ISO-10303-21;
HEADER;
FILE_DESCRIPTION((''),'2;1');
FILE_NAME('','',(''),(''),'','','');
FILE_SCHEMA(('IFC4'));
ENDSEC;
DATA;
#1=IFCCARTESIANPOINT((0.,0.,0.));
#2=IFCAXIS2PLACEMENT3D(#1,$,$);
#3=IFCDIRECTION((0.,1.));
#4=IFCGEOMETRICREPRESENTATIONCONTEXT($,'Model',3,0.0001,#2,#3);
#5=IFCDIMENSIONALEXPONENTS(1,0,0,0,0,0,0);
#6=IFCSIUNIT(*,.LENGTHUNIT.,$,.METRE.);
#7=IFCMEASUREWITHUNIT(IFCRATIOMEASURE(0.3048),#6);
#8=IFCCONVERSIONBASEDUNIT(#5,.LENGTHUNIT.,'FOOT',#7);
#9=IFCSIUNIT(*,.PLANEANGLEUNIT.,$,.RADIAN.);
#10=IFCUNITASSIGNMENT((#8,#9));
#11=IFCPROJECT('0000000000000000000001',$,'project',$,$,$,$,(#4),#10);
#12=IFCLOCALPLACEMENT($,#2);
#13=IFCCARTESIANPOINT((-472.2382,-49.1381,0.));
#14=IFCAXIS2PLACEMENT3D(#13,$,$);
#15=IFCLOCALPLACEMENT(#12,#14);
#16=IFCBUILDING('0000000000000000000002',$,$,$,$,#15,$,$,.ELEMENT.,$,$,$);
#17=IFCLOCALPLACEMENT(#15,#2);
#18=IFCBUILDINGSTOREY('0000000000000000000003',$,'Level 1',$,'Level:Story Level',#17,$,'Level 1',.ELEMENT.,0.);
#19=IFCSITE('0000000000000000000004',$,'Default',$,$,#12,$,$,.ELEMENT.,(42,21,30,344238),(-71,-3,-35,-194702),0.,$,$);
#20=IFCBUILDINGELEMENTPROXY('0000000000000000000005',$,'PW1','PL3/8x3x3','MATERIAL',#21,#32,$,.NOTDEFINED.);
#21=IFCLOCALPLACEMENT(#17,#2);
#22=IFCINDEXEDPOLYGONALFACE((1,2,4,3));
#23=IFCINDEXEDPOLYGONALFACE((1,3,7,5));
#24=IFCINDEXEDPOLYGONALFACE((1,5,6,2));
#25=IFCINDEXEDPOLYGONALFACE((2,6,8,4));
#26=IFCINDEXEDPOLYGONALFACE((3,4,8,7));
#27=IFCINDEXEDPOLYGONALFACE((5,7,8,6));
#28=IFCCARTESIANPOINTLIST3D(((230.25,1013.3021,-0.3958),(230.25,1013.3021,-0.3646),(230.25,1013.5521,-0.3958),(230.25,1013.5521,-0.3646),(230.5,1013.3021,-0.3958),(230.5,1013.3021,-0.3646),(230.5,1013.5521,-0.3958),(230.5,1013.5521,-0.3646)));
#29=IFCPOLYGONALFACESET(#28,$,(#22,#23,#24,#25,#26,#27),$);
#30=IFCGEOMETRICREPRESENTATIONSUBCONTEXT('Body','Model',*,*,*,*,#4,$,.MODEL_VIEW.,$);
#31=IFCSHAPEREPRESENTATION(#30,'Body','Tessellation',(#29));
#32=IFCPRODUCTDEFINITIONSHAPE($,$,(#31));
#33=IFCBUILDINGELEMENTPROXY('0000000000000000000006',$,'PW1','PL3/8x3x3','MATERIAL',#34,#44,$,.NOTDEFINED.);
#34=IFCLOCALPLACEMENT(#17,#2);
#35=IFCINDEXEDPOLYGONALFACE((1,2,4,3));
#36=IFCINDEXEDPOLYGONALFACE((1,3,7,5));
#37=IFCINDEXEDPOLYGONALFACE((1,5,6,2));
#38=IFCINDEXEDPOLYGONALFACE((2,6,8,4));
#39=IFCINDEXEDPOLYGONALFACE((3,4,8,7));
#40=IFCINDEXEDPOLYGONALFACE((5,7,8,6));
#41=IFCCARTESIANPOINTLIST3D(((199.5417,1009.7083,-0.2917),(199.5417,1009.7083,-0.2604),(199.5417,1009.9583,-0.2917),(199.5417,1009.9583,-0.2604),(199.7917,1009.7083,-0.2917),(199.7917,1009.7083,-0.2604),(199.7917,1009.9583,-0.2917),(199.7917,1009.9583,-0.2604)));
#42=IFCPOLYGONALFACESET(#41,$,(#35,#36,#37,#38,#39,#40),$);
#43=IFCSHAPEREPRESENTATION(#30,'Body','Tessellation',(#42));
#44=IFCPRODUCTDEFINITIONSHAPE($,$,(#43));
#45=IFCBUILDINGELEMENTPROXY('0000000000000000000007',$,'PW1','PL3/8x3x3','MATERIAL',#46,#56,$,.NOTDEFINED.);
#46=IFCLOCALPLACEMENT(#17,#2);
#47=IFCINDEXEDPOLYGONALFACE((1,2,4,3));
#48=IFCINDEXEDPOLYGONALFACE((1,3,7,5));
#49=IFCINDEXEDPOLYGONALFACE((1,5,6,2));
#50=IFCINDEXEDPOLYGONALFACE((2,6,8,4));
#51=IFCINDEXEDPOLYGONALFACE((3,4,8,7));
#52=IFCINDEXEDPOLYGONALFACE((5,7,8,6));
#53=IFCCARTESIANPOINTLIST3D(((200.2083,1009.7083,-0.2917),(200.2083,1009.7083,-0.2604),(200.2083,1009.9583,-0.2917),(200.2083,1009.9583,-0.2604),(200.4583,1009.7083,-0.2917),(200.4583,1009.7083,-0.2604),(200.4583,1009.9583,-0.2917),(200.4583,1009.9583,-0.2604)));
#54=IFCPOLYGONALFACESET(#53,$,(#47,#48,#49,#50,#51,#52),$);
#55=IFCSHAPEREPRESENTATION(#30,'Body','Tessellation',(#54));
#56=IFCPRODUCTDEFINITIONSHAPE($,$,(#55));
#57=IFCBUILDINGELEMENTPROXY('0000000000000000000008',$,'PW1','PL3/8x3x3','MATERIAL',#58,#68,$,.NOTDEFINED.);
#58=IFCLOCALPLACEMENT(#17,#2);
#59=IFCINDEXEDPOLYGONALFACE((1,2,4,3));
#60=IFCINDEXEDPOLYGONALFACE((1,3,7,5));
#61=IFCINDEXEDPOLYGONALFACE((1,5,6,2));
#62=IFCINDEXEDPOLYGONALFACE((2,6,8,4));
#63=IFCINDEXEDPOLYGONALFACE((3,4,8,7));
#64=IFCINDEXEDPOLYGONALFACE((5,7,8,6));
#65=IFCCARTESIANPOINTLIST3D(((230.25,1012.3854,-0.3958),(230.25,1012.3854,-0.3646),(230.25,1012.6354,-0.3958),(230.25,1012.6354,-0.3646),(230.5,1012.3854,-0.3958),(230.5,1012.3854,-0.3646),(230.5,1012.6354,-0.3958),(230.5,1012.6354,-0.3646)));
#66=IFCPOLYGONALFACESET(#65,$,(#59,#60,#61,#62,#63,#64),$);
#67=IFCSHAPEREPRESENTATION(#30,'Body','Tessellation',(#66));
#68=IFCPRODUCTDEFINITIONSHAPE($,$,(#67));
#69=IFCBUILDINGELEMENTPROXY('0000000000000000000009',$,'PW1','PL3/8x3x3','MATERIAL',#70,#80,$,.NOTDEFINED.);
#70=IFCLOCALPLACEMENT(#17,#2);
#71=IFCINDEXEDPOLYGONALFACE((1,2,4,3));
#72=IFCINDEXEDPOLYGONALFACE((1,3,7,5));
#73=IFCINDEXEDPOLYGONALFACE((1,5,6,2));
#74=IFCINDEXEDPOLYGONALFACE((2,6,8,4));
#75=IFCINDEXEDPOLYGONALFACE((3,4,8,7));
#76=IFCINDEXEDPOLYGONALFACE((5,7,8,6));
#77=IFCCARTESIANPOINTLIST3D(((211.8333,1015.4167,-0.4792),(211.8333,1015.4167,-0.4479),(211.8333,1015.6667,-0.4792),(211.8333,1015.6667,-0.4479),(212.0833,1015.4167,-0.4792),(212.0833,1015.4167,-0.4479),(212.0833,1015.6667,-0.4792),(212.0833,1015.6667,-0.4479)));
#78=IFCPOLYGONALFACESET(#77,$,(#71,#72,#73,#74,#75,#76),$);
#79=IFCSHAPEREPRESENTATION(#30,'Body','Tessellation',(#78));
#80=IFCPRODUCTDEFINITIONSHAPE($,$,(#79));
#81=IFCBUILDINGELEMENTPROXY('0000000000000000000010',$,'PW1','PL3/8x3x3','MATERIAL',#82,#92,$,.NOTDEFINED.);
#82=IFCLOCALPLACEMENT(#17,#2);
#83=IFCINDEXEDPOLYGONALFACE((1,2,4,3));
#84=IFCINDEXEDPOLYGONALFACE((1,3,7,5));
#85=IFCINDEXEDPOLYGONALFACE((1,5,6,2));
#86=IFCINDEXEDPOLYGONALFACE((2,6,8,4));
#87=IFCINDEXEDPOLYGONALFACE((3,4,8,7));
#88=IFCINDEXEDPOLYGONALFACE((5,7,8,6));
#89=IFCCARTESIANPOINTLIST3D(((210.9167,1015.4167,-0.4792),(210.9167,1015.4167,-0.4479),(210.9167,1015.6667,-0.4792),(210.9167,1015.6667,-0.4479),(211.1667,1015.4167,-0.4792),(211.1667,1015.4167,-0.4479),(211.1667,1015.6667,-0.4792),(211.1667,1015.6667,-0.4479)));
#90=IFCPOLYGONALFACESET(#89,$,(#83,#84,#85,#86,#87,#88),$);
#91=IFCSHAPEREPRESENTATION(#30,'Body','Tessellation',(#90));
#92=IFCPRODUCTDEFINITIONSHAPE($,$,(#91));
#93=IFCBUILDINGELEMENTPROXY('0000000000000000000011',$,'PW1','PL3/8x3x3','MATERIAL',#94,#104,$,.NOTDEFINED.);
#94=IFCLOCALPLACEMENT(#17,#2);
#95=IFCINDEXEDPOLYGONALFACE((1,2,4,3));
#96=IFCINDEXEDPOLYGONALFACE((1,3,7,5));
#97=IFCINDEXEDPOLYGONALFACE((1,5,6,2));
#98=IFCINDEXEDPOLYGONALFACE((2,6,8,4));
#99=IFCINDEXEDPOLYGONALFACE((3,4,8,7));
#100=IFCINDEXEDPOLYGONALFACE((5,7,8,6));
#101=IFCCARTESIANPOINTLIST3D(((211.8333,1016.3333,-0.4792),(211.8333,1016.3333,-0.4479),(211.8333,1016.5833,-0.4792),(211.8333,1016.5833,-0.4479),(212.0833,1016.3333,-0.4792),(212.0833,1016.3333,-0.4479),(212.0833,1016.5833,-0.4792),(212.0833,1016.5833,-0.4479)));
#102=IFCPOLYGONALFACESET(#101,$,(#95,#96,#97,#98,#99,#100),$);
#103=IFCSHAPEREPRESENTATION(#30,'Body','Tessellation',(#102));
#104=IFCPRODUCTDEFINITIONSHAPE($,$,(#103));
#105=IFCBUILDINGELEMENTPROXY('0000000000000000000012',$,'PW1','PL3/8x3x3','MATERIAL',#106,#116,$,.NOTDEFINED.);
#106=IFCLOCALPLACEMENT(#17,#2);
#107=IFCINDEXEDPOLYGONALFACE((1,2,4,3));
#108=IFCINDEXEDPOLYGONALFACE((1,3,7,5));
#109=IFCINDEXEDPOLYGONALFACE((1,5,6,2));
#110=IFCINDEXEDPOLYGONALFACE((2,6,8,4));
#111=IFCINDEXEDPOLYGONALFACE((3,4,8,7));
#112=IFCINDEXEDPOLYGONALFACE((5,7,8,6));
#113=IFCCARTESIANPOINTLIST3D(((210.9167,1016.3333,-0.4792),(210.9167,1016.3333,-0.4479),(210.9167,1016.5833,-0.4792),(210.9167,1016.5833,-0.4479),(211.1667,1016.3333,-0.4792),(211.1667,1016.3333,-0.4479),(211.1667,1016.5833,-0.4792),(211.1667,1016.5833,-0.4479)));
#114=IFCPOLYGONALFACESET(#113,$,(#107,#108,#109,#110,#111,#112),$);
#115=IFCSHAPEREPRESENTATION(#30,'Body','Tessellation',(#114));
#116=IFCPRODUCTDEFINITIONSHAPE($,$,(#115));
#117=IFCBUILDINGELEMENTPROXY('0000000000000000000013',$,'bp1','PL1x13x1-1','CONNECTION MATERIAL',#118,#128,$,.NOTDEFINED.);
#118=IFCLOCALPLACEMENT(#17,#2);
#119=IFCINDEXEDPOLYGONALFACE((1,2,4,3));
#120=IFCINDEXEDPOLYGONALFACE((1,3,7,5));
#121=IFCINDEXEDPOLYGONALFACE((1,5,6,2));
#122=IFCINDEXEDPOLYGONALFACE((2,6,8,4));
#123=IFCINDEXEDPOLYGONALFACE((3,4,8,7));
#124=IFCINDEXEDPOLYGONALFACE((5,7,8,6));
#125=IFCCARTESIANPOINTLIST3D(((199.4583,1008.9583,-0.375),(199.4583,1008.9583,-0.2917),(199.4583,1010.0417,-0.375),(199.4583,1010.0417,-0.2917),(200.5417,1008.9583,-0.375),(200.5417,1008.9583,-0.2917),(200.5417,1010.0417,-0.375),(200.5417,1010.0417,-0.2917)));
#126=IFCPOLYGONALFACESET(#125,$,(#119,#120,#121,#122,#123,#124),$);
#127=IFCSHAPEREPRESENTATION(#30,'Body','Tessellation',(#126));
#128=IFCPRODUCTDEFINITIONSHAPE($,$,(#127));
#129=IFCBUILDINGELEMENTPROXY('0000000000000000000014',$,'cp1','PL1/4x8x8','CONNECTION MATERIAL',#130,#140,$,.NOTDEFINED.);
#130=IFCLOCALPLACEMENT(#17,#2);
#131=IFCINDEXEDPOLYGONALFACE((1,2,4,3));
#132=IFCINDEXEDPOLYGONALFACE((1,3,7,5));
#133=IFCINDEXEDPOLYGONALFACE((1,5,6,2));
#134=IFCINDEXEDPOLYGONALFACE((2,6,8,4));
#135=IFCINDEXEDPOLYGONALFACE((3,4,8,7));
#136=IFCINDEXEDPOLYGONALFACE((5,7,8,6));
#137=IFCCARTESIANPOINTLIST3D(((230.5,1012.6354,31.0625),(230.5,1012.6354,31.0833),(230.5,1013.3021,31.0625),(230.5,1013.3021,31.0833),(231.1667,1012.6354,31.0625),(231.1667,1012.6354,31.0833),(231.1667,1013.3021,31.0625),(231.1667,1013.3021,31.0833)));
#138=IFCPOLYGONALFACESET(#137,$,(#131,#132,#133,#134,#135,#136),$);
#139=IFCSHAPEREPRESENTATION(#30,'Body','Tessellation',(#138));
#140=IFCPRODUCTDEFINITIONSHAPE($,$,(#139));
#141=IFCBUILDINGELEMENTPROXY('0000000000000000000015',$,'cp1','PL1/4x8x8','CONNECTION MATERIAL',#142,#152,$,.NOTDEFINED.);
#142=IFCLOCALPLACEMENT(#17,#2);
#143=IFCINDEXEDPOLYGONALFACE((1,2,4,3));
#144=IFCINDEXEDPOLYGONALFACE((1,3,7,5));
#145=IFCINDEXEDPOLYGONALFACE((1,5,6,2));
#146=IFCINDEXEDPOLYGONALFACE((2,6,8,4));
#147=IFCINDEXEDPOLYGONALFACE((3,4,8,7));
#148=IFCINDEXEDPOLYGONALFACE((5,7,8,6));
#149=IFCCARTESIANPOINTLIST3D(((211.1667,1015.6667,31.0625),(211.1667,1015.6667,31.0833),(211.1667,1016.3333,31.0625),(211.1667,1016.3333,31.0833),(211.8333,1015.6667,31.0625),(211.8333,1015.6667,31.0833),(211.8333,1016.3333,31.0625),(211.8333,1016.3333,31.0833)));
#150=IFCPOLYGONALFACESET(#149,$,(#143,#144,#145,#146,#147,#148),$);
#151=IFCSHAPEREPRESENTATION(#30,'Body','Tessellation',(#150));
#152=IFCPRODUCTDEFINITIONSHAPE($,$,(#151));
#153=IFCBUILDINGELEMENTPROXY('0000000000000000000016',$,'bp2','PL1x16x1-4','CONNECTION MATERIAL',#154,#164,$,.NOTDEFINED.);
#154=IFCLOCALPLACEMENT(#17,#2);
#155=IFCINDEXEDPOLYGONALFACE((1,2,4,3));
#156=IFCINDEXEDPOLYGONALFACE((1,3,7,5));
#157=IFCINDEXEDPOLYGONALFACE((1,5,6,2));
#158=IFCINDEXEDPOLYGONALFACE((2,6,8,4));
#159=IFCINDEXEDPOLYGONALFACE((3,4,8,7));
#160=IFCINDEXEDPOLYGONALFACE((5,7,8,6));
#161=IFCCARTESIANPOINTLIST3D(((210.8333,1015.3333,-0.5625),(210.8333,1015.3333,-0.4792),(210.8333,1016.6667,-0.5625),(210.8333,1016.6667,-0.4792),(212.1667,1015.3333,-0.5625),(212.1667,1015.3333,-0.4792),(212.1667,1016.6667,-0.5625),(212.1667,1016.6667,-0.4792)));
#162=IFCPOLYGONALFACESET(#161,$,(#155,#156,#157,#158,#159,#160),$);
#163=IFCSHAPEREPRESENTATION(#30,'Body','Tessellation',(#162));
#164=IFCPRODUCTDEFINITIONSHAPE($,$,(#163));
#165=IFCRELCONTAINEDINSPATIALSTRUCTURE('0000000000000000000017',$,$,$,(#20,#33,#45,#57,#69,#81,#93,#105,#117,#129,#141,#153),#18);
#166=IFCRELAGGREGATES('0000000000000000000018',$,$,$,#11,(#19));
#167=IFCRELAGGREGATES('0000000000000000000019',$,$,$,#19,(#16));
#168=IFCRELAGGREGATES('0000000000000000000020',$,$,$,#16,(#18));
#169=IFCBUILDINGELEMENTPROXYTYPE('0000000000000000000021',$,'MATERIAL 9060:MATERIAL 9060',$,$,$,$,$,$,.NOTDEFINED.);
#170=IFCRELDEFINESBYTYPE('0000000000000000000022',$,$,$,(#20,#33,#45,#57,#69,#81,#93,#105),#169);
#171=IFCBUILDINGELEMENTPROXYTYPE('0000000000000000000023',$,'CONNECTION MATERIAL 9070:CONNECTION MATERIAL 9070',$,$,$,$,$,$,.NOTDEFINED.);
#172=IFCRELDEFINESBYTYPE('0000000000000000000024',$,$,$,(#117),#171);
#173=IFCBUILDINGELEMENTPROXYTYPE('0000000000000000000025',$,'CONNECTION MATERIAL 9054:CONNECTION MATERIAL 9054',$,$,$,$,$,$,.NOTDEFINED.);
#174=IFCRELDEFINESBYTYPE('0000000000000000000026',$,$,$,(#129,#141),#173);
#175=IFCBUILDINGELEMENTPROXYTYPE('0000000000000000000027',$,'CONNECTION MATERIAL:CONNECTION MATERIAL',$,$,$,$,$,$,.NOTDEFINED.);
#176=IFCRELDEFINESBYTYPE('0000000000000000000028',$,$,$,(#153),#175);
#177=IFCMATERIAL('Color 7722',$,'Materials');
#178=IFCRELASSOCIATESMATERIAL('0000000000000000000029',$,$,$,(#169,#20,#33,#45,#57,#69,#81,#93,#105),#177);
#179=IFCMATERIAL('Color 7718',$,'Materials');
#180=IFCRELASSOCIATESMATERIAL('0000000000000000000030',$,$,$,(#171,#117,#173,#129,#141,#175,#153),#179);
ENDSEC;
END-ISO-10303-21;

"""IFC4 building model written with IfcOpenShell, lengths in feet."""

from ifc_helpers import new_model, entity, si_unit, converted_unit, direction, frame, origin, origin_2d_with_axis, place, context, subcontext, project, spatial, rectangle, extrude, source, transform, mapped, material, type_object, type_shapes, element, save


model = new_model("IFC4")

# Units and contexts
model_context = context("Model", 3, precision=0.0001, world=origin(), true_north=direction((0.0, 1.0)))
body_context = subcontext(model_context, "Body", "Model", "MODEL_VIEW")
ifc_project = project(units=[converted_unit("LENGTHUNIT", "FOOT", entity("IfcRatioMeasure", 0.3048), si_unit("LENGTHUNIT", "METRE"), dimensions=[1, 0, 0, 0, 0, 0, 0]), si_unit("PLANEANGLEUNIT", "RADIAN")], contexts=[model_context])

# Site, building, storey
site_placement = place(None, origin())
site = spatial("IfcSite", under=ifc_project, at=site_placement, Name="Default", CompositionType="ELEMENT", RefLatitude=(42, 21, 30, 344238), RefLongitude=(-71, -3, -35, -194702), RefElevation=0.0)
building_placement = place(site_placement, frame((-472.2382, -49.1381, 0.0)))
building = spatial("IfcBuilding", under=site, at=building_placement, CompositionType="ELEMENT")
storey_placement = place(building_placement, origin())
storey = spatial("IfcBuildingStorey", under=building, at=storey_placement, Name="Level 1", ObjectType="Level:Story Level", LongName="Level 1", CompositionType="ELEMENT", Elevation=0.0)

# Building element proxies
ifc_material_1 = material(Name="Color 7722", Category="Materials")
building_element_proxy_type_1 = type_object("IfcBuildingElementProxyType", Name="MATERIAL 9060:MATERIAL 9060", PredefinedType="NOTDEFINED", material=ifc_material_1)
shared_shape_1 = source(origin(), body_context, "Body", "SweptSolid", [
    extrude(rectangle(XDim=0.25, YDim=0.25, at=origin_2d_with_axis()), frame((0.125, -0.125, 0.0)), (0.0, 0.0, 1.0), 0.0312),
])
type_shapes(building_element_proxy_type_1, [shared_shape_1])
for number, where, z_axis, x_axis, name in (
    (1, (230.25, 1013.5521, -0.3646), (0.0, 0.0, -1.0), (0.0, -1.0, 0.0), "PW1"),
    (2, (199.5417, 1009.9583, -0.2604), (0.0, 0.0, -1.0), (0.0, -1.0, 0.0), "PW1"),
    (3, (200.2083, 1009.9583, -0.2604), (0.0, 0.0, -1.0), (0.0, -1.0, 0.0), "PW1"),
    (4, (230.25, 1012.6354, -0.3646), (0.0, 0.0, -1.0), (0.0, -1.0, 0.0), "PW1"),
    (5, (211.8333, 1015.6667, -0.4479), (0.0, 0.0, -1.0), (0.0, -1.0, 0.0), "PW1"),
    (6, (210.9167, 1015.6667, -0.4479), (0.0, 0.0, -1.0), (0.0, -1.0, 0.0), "PW1"),
    (7, (211.8333, 1016.5833, -0.4479), (0.0, 0.0, -1.0), (0.0, -1.0, 0.0), "PW1"),
    (8, (210.9167, 1016.5833, -0.4479), (0.0, 0.0, -1.0), (0.0, -1.0, 0.0), "PW1"),
):
    element("IfcBuildingElementProxy", number, at=place(building_placement, frame(where, z_axis=z_axis, x_axis=x_axis)), inside=storey, type_object=building_element_proxy_type_1, material=ifc_material_1, Name=name, Description="PL3/8x3x3", ObjectType="MATERIAL", PredefinedType="NOTDEFINED", context=body_context, shape_type="MappedRepresentation", body=[
        mapped(shared_shape_1, transform((0.0, 0.0, 0.0), scale=1.0)),
    ])
ifc_material_2 = material(Name="Color 7718", Category="Materials")
building_element_proxy_type_2 = type_object("IfcBuildingElementProxyType", Name="CONNECTION MATERIAL 9070:CONNECTION MATERIAL 9070", PredefinedType="NOTDEFINED", material=ifc_material_2)
shared_shape_2 = source(origin(), body_context, "Body", "SweptSolid", [
    extrude(rectangle(XDim=1.0833, YDim=1.0833, at=origin_2d_with_axis()), frame((0.0, 0.0, -0.0833)), (0.0, 0.0, 1.0), 0.0833),
])
type_shapes(building_element_proxy_type_2, [shared_shape_2])
proxy_1_placement = place(building_placement, frame((200.0, 1009.5, -0.2917)))
element("IfcBuildingElementProxy", 9, at=proxy_1_placement, inside=storey, type_object=building_element_proxy_type_2, material=ifc_material_2, Name="bp1", Description="PL1x13x1-1", ObjectType="CONNECTION MATERIAL", PredefinedType="NOTDEFINED", context=body_context, shape_type="MappedRepresentation", body=[
    mapped(shared_shape_2, transform((0.0, 0.0, 0.0), scale=1.0)),
])
building_element_proxy_type_3 = type_object("IfcBuildingElementProxyType", Name="CONNECTION MATERIAL 9054:CONNECTION MATERIAL 9054", PredefinedType="NOTDEFINED", material=ifc_material_2)
shared_shape_3 = source(origin(), body_context, "Body", "SweptSolid", [
    extrude(rectangle(XDim=0.6667, YDim=0.6667, at=origin_2d_with_axis()), frame((0.0, 0.0, -0.0208)), (0.0, 0.0, 1.0), 0.0208),
])
type_shapes(building_element_proxy_type_3, [shared_shape_3])
for number, where, z_axis, x_axis, name in (
    (10, (230.8333, 1012.9688, 31.0625), (0.0, 0.0, -1.0), (1.0, 0.0, 0.0), "cp1"),
    (11, (211.5, 1016.0, 31.0625), (0.0, 0.0, -1.0), (1.0, 0.0, 0.0), "cp1"),
):
    element("IfcBuildingElementProxy", number, at=place(building_placement, frame(where, z_axis=z_axis, x_axis=x_axis)), inside=storey, type_object=building_element_proxy_type_3, material=ifc_material_2, Name=name, Description="PL1/4x8x8", ObjectType="CONNECTION MATERIAL", PredefinedType="NOTDEFINED", context=body_context, shape_type="MappedRepresentation", body=[
        mapped(shared_shape_3, transform((0.0, 0.0, 0.0), scale=1.0)),
    ])
building_element_proxy_type_4 = type_object("IfcBuildingElementProxyType", Name="CONNECTION MATERIAL:CONNECTION MATERIAL", PredefinedType="NOTDEFINED", material=ifc_material_2)
shared_shape_4 = source(origin(), body_context, "Body", "SweptSolid", [
    extrude(rectangle(XDim=1.3333, YDim=1.3333, at=origin_2d_with_axis()), frame((0.0, 0.0, -0.0833)), (0.0, 0.0, 1.0), 0.0833),
])
type_shapes(building_element_proxy_type_4, [shared_shape_4])
proxy_2_placement = place(building_placement, frame((211.5, 1016.0, -0.4792)))
element("IfcBuildingElementProxy", 12, at=proxy_2_placement, inside=storey, type_object=building_element_proxy_type_4, material=ifc_material_2, Name="bp2", Description="PL1x16x1-4", ObjectType="CONNECTION MATERIAL", PredefinedType="NOTDEFINED", context=body_context, shape_type="MappedRepresentation", body=[
    mapped(shared_shape_4, transform((0.0, 0.0, 0.0), scale=1.0)),
])

save(model, "model.ifc")
